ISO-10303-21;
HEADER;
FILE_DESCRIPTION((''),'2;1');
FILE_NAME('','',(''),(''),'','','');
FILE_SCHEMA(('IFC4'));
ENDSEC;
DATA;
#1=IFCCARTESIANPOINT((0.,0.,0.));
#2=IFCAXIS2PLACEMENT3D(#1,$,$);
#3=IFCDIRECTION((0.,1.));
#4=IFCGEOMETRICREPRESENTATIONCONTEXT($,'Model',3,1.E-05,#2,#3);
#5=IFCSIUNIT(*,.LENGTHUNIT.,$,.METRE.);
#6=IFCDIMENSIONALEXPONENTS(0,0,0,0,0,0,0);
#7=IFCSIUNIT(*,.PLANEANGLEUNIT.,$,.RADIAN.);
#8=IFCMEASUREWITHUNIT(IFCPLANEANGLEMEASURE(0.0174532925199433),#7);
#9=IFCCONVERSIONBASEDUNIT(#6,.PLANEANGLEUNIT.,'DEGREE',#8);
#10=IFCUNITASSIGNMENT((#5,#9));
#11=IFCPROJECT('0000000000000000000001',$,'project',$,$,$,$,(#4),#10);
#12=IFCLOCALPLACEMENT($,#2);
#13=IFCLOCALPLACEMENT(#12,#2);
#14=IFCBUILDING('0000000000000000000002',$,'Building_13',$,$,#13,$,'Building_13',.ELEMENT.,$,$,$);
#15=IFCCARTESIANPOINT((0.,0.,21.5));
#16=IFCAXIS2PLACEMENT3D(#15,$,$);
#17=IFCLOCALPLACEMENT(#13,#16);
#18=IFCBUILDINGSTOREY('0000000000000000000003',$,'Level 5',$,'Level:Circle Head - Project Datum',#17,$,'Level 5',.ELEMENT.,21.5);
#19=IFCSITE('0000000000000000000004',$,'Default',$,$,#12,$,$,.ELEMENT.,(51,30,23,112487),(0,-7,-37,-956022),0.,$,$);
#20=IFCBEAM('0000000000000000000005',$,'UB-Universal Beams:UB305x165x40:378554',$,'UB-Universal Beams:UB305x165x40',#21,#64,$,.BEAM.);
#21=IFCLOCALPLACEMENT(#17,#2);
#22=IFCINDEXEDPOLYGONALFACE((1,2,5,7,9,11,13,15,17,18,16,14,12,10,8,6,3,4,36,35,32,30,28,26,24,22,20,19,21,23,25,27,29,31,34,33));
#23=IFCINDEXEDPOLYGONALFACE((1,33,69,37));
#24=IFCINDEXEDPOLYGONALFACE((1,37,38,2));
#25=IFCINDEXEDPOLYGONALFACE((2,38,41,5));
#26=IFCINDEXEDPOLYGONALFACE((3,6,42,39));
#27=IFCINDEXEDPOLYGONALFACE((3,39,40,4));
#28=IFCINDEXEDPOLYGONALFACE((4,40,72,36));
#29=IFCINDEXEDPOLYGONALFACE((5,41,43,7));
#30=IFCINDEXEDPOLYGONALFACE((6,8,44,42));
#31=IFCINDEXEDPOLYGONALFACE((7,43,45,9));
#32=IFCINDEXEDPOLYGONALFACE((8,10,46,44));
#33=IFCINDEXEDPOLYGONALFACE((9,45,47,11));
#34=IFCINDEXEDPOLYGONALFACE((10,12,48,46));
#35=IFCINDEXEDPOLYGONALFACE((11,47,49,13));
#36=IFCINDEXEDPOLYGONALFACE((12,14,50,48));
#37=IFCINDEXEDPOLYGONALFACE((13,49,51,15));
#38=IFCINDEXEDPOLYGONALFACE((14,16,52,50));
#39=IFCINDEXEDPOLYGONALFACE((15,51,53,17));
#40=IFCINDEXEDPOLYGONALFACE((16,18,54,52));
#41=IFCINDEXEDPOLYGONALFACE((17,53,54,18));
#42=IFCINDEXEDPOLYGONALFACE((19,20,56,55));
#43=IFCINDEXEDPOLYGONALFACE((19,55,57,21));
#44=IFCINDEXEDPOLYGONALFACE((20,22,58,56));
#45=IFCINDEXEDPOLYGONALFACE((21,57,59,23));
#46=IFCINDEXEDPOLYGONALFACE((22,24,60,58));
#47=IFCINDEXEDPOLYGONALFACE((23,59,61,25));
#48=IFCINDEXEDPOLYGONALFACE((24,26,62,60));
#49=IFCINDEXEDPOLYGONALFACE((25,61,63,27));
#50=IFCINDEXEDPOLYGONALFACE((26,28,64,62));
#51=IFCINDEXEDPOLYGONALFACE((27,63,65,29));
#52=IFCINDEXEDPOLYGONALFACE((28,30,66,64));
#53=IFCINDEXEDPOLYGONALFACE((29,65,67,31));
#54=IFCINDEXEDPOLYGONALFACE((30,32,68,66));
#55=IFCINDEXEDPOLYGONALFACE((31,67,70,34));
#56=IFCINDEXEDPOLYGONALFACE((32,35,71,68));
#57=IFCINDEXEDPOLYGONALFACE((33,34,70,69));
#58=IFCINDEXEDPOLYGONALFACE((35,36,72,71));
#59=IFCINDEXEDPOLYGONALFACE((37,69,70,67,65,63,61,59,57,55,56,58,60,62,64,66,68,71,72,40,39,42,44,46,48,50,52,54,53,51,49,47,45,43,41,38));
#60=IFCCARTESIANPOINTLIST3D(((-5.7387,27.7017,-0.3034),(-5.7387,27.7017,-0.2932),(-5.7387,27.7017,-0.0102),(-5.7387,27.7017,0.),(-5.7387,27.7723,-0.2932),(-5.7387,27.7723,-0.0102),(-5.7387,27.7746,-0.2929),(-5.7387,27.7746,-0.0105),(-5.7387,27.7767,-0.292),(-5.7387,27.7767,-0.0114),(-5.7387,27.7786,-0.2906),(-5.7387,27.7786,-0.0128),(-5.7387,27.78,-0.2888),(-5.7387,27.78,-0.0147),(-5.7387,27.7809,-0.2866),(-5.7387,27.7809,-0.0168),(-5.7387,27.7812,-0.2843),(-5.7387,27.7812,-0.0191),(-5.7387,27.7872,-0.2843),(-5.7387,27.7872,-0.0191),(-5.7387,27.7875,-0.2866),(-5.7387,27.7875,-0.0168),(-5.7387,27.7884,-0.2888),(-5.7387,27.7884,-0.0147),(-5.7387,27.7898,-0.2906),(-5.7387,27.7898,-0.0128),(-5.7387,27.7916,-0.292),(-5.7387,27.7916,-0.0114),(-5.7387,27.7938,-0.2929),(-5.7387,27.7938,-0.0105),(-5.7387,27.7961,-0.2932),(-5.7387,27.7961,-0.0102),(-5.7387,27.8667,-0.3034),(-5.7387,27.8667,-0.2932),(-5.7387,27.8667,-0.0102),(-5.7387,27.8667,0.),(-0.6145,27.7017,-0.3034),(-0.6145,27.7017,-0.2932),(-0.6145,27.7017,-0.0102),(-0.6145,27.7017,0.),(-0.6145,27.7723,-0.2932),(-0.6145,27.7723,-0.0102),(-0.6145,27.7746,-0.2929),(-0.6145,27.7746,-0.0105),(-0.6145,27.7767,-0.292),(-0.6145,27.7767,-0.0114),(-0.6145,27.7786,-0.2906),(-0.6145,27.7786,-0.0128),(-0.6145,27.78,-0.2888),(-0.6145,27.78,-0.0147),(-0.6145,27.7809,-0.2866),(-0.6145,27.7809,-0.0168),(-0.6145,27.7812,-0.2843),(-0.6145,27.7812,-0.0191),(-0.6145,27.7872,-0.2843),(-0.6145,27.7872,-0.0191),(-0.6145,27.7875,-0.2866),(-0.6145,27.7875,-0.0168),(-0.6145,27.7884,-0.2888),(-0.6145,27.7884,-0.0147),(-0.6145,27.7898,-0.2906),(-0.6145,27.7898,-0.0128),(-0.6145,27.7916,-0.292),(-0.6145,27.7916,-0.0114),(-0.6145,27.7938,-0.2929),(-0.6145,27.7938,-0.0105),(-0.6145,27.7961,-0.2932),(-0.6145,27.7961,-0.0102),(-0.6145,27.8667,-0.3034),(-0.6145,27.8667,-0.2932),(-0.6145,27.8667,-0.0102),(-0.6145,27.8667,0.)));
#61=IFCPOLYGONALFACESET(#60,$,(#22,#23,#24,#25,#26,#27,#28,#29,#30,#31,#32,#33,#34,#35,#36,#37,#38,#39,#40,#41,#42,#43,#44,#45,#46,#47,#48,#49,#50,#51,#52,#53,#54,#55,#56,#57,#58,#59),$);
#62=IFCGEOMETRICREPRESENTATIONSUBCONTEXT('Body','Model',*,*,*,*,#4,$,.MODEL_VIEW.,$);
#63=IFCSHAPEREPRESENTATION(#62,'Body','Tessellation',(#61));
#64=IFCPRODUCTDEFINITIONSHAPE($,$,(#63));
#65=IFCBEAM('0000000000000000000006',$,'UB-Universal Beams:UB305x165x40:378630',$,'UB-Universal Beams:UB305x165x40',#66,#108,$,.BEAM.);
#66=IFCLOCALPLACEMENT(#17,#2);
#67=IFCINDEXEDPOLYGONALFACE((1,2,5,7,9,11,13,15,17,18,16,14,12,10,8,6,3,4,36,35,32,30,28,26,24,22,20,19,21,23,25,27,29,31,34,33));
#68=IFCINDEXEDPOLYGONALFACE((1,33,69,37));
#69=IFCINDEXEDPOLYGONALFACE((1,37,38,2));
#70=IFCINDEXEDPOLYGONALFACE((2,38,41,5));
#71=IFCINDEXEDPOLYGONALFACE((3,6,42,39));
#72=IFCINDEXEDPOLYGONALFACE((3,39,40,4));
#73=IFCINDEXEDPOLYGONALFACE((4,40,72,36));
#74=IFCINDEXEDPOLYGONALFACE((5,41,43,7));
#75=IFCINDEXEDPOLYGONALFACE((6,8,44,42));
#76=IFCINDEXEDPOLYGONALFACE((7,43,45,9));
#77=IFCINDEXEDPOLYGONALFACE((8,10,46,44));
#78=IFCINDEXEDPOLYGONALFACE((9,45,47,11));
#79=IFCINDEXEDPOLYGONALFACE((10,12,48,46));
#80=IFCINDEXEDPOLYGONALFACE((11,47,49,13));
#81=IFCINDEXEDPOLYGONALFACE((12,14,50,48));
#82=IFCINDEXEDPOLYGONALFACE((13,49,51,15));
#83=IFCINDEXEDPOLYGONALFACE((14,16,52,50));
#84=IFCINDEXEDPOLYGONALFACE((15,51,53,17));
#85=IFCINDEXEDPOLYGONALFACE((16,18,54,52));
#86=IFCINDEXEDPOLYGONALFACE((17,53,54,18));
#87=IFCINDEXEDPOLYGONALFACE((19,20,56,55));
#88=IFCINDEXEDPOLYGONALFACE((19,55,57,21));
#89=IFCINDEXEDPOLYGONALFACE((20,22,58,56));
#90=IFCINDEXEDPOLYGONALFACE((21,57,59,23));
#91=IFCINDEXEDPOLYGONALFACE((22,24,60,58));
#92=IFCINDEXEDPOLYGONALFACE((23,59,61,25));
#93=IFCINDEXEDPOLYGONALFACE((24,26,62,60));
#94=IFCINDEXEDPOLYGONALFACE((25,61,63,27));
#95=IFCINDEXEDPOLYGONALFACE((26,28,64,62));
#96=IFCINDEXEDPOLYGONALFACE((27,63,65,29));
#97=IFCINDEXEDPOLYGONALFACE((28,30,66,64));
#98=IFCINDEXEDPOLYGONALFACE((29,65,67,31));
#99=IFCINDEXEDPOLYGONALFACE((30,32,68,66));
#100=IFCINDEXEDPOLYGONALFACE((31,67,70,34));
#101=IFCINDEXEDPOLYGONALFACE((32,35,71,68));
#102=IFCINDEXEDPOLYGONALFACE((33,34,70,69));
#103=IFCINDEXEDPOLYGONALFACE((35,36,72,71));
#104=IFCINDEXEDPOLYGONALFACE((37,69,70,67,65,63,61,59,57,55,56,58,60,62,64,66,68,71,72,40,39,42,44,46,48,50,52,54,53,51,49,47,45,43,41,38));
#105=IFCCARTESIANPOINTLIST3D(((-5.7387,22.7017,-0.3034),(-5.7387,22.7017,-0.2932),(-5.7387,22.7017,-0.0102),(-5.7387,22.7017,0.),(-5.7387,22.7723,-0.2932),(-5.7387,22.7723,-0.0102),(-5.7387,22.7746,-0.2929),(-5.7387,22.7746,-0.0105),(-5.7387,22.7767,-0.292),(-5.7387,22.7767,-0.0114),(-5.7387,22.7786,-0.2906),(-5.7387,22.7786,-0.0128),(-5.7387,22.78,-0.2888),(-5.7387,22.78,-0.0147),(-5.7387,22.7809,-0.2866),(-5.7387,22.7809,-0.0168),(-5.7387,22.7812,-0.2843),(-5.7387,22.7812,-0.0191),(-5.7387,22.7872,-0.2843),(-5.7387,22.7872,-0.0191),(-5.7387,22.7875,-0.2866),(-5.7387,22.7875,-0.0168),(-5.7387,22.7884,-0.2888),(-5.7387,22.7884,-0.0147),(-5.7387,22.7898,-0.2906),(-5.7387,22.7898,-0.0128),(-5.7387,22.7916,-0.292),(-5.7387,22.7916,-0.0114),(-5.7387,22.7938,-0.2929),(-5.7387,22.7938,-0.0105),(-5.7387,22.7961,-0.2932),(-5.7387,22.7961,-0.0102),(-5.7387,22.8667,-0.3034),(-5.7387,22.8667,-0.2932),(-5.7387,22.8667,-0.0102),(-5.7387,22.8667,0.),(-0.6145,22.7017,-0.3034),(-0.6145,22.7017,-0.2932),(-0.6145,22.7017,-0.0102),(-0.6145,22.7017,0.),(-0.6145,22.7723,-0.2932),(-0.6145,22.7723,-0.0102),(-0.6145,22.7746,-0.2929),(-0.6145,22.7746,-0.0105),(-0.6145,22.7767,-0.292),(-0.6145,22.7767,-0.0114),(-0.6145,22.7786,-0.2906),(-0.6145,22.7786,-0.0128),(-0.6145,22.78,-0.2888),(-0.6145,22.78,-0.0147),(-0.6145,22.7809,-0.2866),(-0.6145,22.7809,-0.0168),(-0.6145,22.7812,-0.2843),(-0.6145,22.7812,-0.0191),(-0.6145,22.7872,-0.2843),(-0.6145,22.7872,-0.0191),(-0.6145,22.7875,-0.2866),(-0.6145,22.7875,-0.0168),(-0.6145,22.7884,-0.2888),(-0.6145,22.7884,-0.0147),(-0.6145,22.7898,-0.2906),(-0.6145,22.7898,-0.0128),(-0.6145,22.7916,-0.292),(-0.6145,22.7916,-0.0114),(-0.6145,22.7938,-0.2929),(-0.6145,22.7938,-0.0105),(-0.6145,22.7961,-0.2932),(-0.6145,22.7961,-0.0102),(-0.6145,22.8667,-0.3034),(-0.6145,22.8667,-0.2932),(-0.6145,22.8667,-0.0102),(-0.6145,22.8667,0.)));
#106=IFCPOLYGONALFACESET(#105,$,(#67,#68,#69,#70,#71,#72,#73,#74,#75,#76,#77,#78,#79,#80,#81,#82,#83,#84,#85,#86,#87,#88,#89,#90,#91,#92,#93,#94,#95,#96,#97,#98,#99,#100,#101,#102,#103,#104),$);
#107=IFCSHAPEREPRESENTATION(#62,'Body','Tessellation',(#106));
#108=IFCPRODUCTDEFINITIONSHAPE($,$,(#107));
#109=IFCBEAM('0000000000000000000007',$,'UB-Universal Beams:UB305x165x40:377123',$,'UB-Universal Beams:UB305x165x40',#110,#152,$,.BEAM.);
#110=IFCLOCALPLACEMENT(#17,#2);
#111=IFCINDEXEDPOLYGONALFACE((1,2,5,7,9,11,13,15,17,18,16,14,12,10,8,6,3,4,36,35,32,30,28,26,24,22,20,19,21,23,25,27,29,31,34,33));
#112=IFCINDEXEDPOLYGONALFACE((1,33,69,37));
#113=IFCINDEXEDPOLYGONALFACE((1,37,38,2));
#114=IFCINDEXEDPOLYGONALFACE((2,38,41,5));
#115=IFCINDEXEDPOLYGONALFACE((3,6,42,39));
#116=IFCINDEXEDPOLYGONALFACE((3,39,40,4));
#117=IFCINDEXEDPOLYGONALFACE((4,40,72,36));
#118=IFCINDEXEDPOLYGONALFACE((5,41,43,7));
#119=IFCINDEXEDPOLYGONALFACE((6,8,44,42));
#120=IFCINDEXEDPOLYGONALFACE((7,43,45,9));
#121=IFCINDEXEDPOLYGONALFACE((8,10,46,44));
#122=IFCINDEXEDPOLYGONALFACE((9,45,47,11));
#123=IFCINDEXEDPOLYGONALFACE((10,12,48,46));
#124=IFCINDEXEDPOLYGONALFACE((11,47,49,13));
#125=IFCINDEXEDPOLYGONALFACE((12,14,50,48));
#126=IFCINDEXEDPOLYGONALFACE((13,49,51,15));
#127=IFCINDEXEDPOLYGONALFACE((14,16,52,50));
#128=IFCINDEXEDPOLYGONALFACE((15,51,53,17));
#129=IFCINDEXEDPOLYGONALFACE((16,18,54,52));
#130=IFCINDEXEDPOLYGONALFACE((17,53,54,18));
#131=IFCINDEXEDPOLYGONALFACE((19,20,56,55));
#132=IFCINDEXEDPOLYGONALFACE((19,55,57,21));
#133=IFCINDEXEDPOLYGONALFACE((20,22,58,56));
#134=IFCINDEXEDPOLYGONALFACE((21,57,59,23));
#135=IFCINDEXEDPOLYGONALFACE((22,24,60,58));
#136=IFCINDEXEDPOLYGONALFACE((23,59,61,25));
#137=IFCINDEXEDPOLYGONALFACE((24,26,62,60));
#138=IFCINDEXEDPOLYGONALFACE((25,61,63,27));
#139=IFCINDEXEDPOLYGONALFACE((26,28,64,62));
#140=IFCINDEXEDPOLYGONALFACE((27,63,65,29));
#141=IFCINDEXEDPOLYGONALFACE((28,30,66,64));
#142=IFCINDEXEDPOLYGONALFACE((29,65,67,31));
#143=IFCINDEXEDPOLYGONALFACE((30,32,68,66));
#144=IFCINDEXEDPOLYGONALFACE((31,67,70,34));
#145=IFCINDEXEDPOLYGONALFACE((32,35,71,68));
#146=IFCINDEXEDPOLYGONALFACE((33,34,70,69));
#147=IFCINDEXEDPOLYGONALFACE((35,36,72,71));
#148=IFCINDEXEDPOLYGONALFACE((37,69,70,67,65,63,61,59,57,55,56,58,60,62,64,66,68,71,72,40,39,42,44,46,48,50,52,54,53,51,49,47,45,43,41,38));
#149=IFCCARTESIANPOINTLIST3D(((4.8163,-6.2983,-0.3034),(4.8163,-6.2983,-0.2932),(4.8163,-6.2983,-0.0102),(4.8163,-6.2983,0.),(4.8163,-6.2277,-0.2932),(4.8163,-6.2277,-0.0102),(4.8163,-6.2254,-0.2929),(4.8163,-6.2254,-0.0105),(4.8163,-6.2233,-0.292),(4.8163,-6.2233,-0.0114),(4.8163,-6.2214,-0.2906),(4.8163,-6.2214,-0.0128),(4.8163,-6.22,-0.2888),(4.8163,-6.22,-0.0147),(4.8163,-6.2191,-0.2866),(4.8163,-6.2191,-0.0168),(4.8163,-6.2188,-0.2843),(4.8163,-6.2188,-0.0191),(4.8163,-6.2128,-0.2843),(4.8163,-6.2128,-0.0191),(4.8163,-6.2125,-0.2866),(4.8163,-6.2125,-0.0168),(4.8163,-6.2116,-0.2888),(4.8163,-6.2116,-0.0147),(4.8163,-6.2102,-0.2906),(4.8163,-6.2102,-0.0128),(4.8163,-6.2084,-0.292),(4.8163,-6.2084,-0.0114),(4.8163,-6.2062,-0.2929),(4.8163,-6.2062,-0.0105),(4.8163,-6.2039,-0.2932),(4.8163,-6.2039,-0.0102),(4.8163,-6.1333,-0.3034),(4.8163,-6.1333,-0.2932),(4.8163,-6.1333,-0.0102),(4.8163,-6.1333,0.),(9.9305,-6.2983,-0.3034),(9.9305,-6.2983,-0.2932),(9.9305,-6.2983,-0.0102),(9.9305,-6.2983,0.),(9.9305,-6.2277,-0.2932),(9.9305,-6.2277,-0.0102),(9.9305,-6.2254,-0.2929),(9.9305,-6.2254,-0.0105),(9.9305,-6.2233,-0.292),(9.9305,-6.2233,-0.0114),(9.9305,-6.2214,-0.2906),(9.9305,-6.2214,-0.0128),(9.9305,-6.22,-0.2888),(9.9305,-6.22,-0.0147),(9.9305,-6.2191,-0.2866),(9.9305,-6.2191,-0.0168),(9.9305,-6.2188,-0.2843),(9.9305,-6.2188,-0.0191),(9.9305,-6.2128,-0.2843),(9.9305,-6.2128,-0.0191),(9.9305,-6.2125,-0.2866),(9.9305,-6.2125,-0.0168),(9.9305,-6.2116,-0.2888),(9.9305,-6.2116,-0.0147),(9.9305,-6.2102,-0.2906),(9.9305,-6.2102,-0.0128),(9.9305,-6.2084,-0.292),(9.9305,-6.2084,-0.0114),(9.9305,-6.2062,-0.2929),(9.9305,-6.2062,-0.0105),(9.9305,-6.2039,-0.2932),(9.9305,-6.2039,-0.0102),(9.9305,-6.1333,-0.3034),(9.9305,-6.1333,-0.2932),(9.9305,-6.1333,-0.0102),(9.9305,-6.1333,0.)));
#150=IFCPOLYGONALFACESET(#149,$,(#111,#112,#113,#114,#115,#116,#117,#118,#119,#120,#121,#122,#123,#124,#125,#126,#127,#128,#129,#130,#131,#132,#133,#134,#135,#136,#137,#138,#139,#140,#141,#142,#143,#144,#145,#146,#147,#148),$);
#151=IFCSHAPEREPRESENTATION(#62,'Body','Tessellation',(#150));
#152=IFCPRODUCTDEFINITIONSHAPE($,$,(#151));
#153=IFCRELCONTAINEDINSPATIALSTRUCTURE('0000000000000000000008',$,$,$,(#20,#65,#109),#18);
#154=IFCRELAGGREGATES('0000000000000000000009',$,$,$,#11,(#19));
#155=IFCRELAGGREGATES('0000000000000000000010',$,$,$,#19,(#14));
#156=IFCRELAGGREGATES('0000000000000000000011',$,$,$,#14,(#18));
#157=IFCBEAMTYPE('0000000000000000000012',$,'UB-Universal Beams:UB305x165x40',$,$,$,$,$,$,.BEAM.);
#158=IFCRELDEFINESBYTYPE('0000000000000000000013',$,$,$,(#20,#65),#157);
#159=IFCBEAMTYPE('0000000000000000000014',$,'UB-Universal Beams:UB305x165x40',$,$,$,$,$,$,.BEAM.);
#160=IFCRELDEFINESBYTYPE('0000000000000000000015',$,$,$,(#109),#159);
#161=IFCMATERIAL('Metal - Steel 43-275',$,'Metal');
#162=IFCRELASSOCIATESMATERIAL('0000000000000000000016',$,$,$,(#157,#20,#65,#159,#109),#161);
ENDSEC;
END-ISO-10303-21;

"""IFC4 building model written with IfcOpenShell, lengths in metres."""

from ifc_helpers import new_model, entity, si_unit, converted_unit, direction, frame, origin, place, context, subcontext, project, spatial, line, arc, indexed_curve, outline, extrude, source, transform, mapped, material, type_object, type_shapes, element, save


model = new_model("IFC4")

# Units and contexts
model_context = context("Model", 3, precision=1e-05, world=origin(), true_north=direction((0.0, 1.0)))
body_context = subcontext(model_context, "Body", "Model", "MODEL_VIEW")
ifc_project = project(units=[si_unit("LENGTHUNIT", "METRE"), converted_unit("PLANEANGLEUNIT", "DEGREE", entity("IfcPlaneAngleMeasure", 0.0174532925199433), si_unit("PLANEANGLEUNIT", "RADIAN"), dimensions=[0, 0, 0, 0, 0, 0, 0])], contexts=[model_context])

# Site, building, storey
site_placement = place(None, origin())
site = spatial("IfcSite", under=ifc_project, at=site_placement, Name="Default", CompositionType="ELEMENT", RefLatitude=(51, 30, 23, 112487), RefLongitude=(0, -7, -37, -956022), RefElevation=0.0)
building_placement = place(site_placement, origin())
building = spatial("IfcBuilding", under=site, at=building_placement, Name="Building_13", LongName="Building_13", CompositionType="ELEMENT")
storey_placement = place(building_placement, frame((0.0, 0.0, 21.5)))
storey = spatial("IfcBuildingStorey", under=building, at=storey_placement, Name="Level 5", ObjectType="Level:Circle Head - Project Datum", LongName="Level 5", CompositionType="ELEMENT", Elevation=21.5)

# Beams
ifc_material = material(Name="Metal - Steel 43-275", Category="Metal")
beam_type_1 = type_object("IfcBeamType", Name="UB-Universal Beams:UB305x165x40", PredefinedType="BEAM", material=ifc_material)
shared_shape_1 = source(origin(), body_context, "Body", "SweptSolid", [
    extrude(outline(indexed_curve([(-0.0825, -0.1415), (-0.0825, -0.1517), (0.0825, -0.1517), (0.0825, -0.1415), (0.0119, -0.1415), (0.0056, -0.1389), (0.003, -0.1326), (0.003, 0.1326), (0.0056, 0.1389), (0.0119, 0.1415), (0.0825, 0.1415), (0.0825, 0.1517), (-0.0825, 0.1517), (-0.0825, 0.1415), (-0.0119, 0.1415), (-0.0056, 0.1389), (-0.003, 0.1326), (-0.003, -0.1326), (-0.0056, -0.1389), (-0.0119, -0.1415)], segments=[line(1, 2, 3, 4, 5), arc(5, 6, 7), line(7, 8), arc(8, 9, 10), line(10, 11, 12, 13, 14, 15), arc(15, 16, 17), line(17, 18), arc(18, 19, 20), line(20, 1)], self_intersect=False)), frame((-2.5621, 0.0, 0.0), z_axis=(-1.0, 0.0, 0.0), x_axis=(0.0, -1.0, 0.0)), (0.0, 0.0, -1.0), 5.1242),
])
type_shapes(beam_type_1, [shared_shape_1])
for number, where, name in (
    (1, (-3.1766, 27.7842, -0.1517), "UB-Universal Beams:UB305x165x40:378554"),
    (2, (-3.1766, 22.7842, -0.1517), "UB-Universal Beams:UB305x165x40:378630"),
):
    element("IfcBeam", number, at=place(storey_placement, frame(where)), inside=storey, type_object=beam_type_1, material=ifc_material, Name=name, ObjectType="UB-Universal Beams:UB305x165x40", PredefinedType="BEAM", context=body_context, shape_type="MappedRepresentation", body=[
        mapped(shared_shape_1, transform((0.0, 0.0, 0.0), scale=1.0)),
    ])
beam_type_2 = type_object("IfcBeamType", Name="UB-Universal Beams:UB305x165x40", PredefinedType="BEAM", material=ifc_material)
shared_shape_2 = source(origin(), body_context, "Body", "SweptSolid", [
    extrude(outline(indexed_curve([(-0.0825, -0.1415), (-0.0825, -0.1517), (0.0825, -0.1517), (0.0825, -0.1415), (0.0119, -0.1415), (0.0056, -0.1389), (0.003, -0.1326), (0.003, 0.1326), (0.0056, 0.1389), (0.0119, 0.1415), (0.0825, 0.1415), (0.0825, 0.1517), (-0.0825, 0.1517), (-0.0825, 0.1415), (-0.0119, 0.1415), (-0.0056, 0.1389), (-0.003, 0.1326), (-0.003, -0.1326), (-0.0056, -0.1389), (-0.0119, -0.1415)], segments=[line(1, 2, 3, 4, 5), arc(5, 6, 7), line(7, 8), arc(8, 9, 10), line(10, 11, 12, 13, 14, 15), arc(15, 16, 17), line(17, 18), arc(18, 19, 20), line(20, 1)], self_intersect=False)), frame((-2.5571, 0.0, 0.0), z_axis=(-1.0, 0.0, 0.0), x_axis=(0.0, -1.0, 0.0)), (0.0, 0.0, -1.0), 5.1142),
])
type_shapes(beam_type_2, [shared_shape_2])
beam_1_placement = place(storey_placement, frame((7.3734, -6.2158, -0.1517)))
element("IfcBeam", 3, at=beam_1_placement, inside=storey, type_object=beam_type_2, material=ifc_material, Name="UB-Universal Beams:UB305x165x40:377123", ObjectType="UB-Universal Beams:UB305x165x40", PredefinedType="BEAM", context=body_context, shape_type="MappedRepresentation", body=[
    mapped(shared_shape_2, transform((0.0, 0.0, 0.0), scale=1.0)),
])

save(model, "model.ifc")
